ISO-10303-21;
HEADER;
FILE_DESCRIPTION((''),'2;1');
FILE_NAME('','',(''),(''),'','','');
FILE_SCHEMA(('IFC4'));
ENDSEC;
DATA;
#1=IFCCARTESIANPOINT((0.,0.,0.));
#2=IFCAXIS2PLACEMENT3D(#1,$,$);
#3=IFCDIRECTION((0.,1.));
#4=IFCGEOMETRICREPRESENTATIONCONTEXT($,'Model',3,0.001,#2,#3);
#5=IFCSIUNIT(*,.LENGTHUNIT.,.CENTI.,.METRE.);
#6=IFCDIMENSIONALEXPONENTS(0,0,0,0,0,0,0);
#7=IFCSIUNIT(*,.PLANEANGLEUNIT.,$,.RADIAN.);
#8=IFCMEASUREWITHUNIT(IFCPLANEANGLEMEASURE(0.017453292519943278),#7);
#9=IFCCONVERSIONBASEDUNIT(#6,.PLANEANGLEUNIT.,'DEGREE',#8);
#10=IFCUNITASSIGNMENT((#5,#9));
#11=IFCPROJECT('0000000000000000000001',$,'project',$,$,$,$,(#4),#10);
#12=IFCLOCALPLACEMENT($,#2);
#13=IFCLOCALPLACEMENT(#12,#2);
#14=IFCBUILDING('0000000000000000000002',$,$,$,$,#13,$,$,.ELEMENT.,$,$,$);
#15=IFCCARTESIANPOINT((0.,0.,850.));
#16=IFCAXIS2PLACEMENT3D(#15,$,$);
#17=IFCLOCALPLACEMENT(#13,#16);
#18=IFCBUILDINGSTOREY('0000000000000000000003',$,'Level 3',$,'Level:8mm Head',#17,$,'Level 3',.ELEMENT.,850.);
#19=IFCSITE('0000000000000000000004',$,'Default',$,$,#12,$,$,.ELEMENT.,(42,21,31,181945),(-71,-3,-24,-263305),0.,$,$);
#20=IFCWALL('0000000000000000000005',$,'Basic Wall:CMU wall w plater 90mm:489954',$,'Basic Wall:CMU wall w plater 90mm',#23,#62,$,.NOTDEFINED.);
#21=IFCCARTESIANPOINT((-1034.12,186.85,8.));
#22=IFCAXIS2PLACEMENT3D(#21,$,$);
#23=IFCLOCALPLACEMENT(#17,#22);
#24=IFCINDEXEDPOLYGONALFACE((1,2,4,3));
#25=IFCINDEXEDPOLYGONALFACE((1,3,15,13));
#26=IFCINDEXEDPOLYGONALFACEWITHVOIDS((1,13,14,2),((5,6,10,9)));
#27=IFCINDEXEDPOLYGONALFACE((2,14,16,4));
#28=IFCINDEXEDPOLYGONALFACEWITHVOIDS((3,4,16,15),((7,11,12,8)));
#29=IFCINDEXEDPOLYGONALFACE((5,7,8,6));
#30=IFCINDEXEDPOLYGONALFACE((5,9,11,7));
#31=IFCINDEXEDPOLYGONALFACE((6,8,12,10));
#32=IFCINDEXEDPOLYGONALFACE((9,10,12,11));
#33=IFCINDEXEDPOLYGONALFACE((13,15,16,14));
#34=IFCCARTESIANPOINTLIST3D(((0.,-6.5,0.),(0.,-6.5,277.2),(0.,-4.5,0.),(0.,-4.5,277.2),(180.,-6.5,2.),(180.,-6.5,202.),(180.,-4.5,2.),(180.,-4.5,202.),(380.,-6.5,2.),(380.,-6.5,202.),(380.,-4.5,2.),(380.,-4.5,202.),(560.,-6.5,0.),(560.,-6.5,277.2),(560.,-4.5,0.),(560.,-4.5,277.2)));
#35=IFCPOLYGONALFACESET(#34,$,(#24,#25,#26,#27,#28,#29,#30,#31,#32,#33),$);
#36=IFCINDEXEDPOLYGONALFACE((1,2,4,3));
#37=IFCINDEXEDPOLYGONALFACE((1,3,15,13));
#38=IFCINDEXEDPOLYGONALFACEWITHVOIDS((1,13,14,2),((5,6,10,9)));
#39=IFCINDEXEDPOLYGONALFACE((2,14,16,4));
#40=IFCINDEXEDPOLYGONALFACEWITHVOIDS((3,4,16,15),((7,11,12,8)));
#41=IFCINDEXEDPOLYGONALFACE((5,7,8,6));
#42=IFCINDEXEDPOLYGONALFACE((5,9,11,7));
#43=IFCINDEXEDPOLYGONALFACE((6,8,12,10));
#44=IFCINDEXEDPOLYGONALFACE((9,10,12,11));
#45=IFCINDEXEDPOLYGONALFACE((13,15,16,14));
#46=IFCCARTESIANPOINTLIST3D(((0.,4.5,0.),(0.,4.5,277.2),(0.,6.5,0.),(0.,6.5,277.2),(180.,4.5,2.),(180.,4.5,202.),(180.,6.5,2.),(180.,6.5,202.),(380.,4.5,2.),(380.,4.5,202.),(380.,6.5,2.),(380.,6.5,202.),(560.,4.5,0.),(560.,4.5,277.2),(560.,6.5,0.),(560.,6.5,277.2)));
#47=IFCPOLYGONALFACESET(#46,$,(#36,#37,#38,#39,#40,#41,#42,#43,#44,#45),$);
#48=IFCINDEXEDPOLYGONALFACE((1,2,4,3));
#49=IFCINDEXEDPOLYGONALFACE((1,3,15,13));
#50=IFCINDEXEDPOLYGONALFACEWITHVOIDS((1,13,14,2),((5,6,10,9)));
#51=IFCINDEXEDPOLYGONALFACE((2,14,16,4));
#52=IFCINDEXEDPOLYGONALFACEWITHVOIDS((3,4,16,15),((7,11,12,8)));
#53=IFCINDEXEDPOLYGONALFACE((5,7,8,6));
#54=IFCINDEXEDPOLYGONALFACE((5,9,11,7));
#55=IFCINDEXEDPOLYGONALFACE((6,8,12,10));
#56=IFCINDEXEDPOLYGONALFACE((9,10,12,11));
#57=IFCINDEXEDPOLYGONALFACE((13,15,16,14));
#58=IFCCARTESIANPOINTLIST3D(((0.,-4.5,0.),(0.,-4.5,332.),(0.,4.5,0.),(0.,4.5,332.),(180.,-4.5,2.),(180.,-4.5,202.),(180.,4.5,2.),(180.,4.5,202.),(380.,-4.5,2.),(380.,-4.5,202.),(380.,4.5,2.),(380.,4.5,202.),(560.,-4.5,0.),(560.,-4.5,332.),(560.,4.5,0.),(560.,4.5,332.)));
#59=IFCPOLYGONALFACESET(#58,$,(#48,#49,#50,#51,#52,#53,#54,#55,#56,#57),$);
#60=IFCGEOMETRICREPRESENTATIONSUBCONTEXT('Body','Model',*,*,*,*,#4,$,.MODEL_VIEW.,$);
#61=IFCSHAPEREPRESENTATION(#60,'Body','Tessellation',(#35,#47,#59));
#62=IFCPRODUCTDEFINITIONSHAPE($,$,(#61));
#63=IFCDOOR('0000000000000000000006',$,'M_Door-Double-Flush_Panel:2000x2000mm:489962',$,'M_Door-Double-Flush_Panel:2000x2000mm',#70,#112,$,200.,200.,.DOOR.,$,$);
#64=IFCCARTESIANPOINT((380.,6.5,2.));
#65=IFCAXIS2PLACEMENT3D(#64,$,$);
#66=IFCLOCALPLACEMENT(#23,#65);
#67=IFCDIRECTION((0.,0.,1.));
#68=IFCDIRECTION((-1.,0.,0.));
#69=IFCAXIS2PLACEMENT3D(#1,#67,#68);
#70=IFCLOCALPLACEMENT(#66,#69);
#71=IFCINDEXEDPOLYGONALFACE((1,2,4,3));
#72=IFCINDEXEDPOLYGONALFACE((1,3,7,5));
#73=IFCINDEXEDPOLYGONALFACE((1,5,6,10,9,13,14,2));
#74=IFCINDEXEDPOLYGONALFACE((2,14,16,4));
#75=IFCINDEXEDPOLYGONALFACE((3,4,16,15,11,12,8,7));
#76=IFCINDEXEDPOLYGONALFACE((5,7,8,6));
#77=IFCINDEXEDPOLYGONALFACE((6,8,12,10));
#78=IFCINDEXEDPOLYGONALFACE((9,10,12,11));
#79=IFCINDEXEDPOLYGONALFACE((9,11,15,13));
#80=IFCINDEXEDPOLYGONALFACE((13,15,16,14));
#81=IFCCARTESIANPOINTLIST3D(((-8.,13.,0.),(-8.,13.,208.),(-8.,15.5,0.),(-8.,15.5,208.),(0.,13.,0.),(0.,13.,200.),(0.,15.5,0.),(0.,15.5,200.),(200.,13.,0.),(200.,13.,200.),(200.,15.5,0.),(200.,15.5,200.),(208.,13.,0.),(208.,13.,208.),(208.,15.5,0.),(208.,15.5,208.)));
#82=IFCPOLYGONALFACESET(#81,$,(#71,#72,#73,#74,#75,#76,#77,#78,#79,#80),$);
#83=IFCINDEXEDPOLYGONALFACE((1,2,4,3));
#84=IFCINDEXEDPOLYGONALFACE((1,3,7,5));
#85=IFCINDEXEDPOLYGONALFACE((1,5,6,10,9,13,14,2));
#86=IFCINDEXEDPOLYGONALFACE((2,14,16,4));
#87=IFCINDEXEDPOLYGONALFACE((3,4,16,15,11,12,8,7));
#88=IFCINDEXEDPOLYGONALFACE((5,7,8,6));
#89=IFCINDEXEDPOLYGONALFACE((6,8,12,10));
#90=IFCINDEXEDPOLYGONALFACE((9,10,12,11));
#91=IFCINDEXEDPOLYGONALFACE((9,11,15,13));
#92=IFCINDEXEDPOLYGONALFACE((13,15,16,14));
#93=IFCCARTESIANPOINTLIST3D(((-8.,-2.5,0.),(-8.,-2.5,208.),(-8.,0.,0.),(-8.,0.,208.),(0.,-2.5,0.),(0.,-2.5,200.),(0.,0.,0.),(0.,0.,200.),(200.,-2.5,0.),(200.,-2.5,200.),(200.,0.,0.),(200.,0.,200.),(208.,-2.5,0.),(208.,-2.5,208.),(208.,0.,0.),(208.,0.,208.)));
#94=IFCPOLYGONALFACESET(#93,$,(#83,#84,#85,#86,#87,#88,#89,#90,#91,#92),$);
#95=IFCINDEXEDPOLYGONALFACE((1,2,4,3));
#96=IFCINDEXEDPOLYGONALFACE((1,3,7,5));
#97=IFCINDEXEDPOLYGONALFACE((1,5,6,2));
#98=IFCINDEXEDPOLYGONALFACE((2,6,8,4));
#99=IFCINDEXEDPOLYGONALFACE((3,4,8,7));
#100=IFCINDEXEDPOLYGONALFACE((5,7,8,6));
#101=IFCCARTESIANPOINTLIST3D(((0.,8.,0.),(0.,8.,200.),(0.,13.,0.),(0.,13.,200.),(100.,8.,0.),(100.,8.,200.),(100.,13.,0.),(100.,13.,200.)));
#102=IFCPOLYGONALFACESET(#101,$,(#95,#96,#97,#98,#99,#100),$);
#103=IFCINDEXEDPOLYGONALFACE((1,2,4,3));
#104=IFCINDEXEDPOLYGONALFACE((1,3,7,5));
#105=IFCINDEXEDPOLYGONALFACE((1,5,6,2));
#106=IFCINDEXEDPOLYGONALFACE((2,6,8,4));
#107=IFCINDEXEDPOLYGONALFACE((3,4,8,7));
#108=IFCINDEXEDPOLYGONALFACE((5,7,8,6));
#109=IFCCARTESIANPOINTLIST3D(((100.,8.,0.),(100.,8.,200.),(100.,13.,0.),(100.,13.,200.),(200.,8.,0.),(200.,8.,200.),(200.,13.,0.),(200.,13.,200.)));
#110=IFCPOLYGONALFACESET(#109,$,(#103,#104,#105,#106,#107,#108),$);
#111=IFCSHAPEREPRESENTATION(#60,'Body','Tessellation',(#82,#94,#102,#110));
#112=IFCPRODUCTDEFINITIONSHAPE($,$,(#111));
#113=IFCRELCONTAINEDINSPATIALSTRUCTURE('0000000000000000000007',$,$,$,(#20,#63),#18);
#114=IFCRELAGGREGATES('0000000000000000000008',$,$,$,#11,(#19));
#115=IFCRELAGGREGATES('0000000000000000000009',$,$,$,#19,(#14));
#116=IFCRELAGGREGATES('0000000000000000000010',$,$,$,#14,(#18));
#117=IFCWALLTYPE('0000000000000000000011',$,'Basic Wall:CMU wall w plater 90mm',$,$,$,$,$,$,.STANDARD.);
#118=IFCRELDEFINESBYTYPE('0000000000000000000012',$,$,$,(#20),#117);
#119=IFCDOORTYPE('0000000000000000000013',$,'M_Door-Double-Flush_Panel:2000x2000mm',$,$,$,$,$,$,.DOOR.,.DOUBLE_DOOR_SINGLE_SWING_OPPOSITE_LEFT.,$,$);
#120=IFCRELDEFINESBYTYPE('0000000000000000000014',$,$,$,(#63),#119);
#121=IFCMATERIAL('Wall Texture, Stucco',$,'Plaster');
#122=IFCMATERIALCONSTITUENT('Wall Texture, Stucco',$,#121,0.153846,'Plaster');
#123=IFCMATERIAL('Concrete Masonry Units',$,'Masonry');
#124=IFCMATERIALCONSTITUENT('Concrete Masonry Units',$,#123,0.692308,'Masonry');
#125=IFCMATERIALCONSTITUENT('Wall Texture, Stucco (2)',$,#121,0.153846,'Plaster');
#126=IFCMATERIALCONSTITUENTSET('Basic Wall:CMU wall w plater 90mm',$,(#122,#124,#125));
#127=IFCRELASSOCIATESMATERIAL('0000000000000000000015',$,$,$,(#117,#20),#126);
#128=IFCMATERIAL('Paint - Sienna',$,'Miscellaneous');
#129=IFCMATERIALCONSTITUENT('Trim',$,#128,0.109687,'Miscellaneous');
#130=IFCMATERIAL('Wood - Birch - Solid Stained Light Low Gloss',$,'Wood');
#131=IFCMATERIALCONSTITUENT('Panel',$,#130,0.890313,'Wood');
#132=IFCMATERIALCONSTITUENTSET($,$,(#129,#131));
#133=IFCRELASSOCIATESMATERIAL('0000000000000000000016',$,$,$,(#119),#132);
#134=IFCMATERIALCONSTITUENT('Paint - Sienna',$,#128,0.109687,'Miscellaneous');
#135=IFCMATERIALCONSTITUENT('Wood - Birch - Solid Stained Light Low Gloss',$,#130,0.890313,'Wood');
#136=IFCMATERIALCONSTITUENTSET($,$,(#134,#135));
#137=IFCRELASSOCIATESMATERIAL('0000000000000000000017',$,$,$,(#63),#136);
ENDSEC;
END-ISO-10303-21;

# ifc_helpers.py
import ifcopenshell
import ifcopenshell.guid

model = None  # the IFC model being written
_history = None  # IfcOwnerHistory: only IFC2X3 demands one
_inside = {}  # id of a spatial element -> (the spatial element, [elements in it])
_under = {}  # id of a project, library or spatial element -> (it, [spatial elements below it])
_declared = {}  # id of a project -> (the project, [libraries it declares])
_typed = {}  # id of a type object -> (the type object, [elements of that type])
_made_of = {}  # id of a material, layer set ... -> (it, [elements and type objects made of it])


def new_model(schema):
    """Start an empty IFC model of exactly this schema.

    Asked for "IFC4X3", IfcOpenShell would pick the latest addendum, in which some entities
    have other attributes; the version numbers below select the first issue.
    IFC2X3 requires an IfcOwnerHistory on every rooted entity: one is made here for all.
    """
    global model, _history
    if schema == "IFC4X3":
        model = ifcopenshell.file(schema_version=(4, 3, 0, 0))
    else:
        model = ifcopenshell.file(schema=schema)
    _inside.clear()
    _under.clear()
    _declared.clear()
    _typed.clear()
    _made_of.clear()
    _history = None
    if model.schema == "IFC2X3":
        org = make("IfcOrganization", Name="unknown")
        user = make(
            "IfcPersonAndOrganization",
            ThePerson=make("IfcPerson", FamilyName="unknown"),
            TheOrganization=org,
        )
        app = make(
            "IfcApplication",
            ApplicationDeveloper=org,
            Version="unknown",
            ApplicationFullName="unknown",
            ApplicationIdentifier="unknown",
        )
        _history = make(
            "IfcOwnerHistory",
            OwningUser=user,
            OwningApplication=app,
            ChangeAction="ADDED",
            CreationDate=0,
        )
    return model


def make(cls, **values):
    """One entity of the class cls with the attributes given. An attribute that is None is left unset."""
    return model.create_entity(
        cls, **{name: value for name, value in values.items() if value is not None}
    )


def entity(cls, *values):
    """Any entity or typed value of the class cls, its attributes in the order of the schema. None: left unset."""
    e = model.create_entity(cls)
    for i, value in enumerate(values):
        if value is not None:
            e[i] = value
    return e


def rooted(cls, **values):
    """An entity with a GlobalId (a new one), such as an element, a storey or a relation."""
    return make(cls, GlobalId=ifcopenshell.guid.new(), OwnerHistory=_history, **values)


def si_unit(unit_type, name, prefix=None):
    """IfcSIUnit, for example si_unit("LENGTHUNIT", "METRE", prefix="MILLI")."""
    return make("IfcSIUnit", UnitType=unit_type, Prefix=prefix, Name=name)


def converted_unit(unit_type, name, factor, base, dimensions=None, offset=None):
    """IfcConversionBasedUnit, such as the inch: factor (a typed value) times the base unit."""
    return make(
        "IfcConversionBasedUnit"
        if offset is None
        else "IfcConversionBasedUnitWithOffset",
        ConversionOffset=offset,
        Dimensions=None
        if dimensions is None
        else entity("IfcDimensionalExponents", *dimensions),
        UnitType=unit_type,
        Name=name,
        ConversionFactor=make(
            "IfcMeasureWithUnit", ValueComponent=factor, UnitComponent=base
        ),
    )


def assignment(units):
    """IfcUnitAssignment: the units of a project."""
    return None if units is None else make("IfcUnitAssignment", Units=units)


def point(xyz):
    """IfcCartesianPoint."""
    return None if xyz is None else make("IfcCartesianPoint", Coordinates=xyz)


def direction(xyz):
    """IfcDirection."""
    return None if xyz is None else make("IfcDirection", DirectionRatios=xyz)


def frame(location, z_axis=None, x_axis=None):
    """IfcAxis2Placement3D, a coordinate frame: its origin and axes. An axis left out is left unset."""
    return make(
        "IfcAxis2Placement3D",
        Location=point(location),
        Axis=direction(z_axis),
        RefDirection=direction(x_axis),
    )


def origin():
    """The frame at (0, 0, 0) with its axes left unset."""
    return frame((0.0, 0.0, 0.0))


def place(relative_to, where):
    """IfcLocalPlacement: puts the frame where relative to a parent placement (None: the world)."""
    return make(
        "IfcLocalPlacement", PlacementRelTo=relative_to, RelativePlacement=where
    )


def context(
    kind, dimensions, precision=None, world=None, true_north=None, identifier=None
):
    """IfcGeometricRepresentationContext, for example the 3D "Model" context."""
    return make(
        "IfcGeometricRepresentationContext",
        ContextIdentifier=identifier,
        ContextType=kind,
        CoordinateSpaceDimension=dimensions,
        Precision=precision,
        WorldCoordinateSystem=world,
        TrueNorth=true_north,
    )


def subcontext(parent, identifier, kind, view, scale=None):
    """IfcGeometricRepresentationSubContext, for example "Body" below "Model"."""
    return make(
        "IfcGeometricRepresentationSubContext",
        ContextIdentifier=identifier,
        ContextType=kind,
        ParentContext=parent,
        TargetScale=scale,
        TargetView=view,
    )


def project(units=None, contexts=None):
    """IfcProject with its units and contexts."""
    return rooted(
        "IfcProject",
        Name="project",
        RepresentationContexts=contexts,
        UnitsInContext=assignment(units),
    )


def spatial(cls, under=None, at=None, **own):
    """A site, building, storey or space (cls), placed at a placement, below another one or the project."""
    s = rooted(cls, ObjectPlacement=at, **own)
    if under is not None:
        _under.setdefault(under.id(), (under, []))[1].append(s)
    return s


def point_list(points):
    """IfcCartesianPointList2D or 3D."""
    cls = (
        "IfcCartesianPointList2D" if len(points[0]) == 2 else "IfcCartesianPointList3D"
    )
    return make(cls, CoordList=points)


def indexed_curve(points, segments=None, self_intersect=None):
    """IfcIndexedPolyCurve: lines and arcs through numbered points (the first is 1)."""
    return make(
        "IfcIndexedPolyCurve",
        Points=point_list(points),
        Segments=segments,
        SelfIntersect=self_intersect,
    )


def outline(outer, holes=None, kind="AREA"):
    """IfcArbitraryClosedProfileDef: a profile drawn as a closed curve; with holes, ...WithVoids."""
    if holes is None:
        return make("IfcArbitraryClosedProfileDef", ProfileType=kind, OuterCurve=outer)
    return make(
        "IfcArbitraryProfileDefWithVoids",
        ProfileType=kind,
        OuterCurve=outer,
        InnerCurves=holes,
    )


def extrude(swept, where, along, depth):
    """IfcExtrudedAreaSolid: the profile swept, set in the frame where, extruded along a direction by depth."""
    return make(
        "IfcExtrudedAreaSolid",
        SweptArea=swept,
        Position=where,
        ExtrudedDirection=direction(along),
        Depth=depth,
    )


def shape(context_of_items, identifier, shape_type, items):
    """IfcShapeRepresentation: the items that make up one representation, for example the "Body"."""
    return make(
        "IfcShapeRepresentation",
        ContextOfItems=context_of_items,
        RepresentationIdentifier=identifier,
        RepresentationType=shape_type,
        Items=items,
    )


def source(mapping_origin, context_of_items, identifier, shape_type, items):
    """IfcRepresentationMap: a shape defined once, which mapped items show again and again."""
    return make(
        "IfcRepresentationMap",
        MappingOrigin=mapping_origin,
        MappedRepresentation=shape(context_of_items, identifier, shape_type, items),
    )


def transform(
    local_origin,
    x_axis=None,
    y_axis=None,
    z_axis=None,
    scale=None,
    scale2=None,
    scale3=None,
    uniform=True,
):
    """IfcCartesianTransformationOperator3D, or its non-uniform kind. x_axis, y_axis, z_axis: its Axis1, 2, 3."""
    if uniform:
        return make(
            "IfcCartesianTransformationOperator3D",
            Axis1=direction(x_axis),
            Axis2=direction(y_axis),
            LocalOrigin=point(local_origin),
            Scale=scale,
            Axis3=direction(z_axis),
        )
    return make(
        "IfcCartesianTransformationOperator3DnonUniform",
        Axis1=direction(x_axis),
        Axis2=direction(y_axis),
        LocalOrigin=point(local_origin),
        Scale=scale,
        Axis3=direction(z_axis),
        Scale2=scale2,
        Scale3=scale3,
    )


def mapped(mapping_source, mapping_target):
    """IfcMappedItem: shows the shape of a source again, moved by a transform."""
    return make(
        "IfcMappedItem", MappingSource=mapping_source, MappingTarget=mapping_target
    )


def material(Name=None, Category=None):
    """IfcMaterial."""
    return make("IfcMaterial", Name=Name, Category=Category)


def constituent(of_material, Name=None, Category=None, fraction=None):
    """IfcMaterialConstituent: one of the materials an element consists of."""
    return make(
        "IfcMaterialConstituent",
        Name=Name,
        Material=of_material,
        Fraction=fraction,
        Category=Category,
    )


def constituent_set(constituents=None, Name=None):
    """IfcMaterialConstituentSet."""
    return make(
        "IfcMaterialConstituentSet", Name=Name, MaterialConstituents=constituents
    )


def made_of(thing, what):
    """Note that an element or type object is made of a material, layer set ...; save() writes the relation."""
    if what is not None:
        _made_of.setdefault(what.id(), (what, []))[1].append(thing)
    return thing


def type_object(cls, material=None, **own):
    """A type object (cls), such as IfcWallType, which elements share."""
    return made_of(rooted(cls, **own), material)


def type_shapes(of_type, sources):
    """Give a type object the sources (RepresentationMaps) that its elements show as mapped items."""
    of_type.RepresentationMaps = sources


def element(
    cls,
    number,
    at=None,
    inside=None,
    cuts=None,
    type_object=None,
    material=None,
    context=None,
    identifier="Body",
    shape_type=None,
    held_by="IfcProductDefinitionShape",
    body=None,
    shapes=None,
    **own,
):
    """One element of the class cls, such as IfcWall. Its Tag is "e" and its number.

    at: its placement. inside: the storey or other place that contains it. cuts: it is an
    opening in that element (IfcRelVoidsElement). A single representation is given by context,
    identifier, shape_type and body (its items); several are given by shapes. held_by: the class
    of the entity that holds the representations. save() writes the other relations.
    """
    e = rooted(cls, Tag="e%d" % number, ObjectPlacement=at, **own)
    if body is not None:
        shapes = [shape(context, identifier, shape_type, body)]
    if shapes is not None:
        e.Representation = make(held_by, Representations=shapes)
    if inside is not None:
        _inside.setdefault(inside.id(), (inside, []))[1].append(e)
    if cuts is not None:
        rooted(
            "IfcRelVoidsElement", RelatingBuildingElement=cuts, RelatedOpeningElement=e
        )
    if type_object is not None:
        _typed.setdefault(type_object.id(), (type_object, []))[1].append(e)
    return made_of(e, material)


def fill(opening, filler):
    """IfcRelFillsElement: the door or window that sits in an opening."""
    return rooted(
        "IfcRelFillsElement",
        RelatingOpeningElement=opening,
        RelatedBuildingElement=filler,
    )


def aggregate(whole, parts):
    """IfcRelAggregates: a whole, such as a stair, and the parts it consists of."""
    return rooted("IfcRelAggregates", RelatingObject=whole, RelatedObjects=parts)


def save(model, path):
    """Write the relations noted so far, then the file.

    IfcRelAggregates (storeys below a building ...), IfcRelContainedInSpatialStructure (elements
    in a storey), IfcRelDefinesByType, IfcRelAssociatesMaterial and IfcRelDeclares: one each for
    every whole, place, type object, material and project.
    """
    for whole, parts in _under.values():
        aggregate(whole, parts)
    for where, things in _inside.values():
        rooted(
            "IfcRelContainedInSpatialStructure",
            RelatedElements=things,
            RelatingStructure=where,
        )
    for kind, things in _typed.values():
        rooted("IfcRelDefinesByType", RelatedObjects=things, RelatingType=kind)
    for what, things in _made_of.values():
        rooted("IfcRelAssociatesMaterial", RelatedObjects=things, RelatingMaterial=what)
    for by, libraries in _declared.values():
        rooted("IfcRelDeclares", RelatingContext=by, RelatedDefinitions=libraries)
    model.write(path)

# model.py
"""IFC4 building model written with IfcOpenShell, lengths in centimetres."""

from ifc_helpers import new_model, entity, si_unit, converted_unit, direction, frame, origin, place, context, subcontext, project, spatial, indexed_curve, outline, extrude, source, transform, mapped, material, constituent, constituent_set, type_object, type_shapes, element, fill, save


model = new_model("IFC4")

# Units and contexts
model_context = context("Model", 3, precision=0.001, world=origin(), true_north=direction((0.0, 1.0)))
body_context = subcontext(model_context, "Body", "Model", "MODEL_VIEW")
ifc_project = project(units=[si_unit("LENGTHUNIT", "METRE", prefix="CENTI"), converted_unit("PLANEANGLEUNIT", "DEGREE", entity("IfcPlaneAngleMeasure", 0.017453292519943278), si_unit("PLANEANGLEUNIT", "RADIAN"), dimensions=[0, 0, 0, 0, 0, 0, 0])], contexts=[model_context])

# Site, building, storey
site_placement = place(None, origin())
site = spatial("IfcSite", under=ifc_project, at=site_placement, Name="Default", CompositionType="ELEMENT", RefLatitude=(42, 21, 31, 181945), RefLongitude=(-71, -3, -24, -263305), RefElevation=0.0)
building_placement = place(site_placement, origin())
building = spatial("IfcBuilding", under=site, at=building_placement, CompositionType="ELEMENT")
storey_placement = place(building_placement, frame((0.0, 0.0, 850.0)))
storey = spatial("IfcBuildingStorey", under=building, at=storey_placement, Name="Level 3", ObjectType="Level:8mm Head", LongName="Level 3", CompositionType="ELEMENT", Elevation=850.0)

# Shared definitions
ifc_material_1 = material(Name="Concrete Masonry Units", Category="Masonry")

# Shared definitions
ifc_material_2 = material(Name="Wall Texture, Stucco", Category="Plaster")
ifc_constituent_1 = constituent(ifc_material_2, Name="Wall Texture, Stucco", Category="Plaster", fraction=0.153846)
ifc_constituent_2 = constituent(ifc_material_1, Name="Concrete Masonry Units", Category="Masonry", fraction=0.692308)
ifc_constituent_3 = constituent(ifc_material_2, Name="Wall Texture, Stucco (2)", Category="Plaster", fraction=0.153846)
ifc_constituent_set_1 = constituent_set(constituents=[ifc_constituent_1, ifc_constituent_2, ifc_constituent_3], Name="Basic Wall:CMU wall w plater 90mm")
wall_type_1 = type_object("IfcWallType", Name="Basic Wall:CMU wall w plater 90mm", PredefinedType="STANDARD", material=ifc_constituent_set_1)

# Wall, opening, door
wall_1_placement = place(storey_placement, frame((-1034.12, 186.85, 8.0)))
wall_1 = element("IfcWall", 1, at=wall_1_placement, inside=storey, type_object=wall_type_1, material=ifc_constituent_set_1, Name="Basic Wall:CMU wall w plater 90mm:489954", ObjectType="Basic Wall:CMU wall w plater 90mm", PredefinedType="NOTDEFINED", context=body_context, shape_type="SweptSolid", body=[
    extrude(outline(indexed_curve([(-138.6, -280.0), (138.6, -280.0), (138.6, -278.0), (138.6, 278.0), (138.6, 280.0), (-138.6, 280.0), (-138.6, 278.0), (-138.6, -278.0), (-138.6, -280.0)], self_intersect=False), holes=[indexed_curve([(-136.6, -100.0), (-136.6, 100.0), (63.4, 100.0), (63.4, -100.0), (-136.6, -100.0)], self_intersect=False)]), frame((280.0, -6.5, 138.6), z_axis=(0.0, 1.0, 0.0), x_axis=(0.0, 0.0, 1.0)), (0.0, 0.0, 1.0), 2.0),
    extrude(outline(indexed_curve([(-138.6, -280.0), (138.6, -280.0), (138.6, 280.0), (-138.6, 280.0), (-138.6, -280.0)], self_intersect=False), holes=[indexed_curve([(-136.6, -100.0), (-136.6, 100.0), (63.4, 100.0), (63.4, -100.0), (-136.6, -100.0)], self_intersect=False)]), frame((280.0, 4.5, 138.6), z_axis=(0.0, 1.0, 0.0), x_axis=(0.0, 0.0, 1.0)), (0.0, 0.0, 1.0), 2.0),
    extrude(outline(indexed_curve([(-203.07, -280.0), (74.13, -280.0), (128.93, -280.0), (128.93, 280.0), (74.13, 280.0), (-203.07, 280.0), (-203.07, -280.0)], self_intersect=False), holes=[indexed_curve([(-201.07, -100.0), (-201.07, 100.0), (-1.07, 100.0), (-1.07, -100.0), (-201.07, -100.0)], self_intersect=False)]), frame((280.0, -4.5, 203.07), z_axis=(0.0, 1.0, 0.0), x_axis=(0.0, 0.0, 1.0)), (0.0, 0.0, 1.0), 9.0),
])
opening_1_placement = place(wall_1_placement, frame((380.0, 6.5, 2.0)))
opening_1 = element("IfcOpeningElement", 2, at=opening_1_placement, cuts=wall_1, PredefinedType="OPENING", context=body_context, shape_type="SweptSolid", body=[
    extrude(outline(indexed_curve([(0.0, 200.0), (0.0, 0.0), (200.0, 0.0), (200.0, 200.0), (0.0, 200.0)], self_intersect=False)), frame((0.0, 0.0, 0.0), z_axis=(0.0, -1.0, 0.0), x_axis=(0.0, 0.0, 1.0)), (0.0, 0.0, 1.0), 13.0),
])
ifc_material_3 = material(Name="Paint - Sienna", Category="Miscellaneous")
ifc_constituent_4 = constituent(ifc_material_3, Name="Paint - Sienna", Category="Miscellaneous", fraction=0.109687)
ifc_material_4 = material(Name="Wood - Birch - Solid Stained Light Low Gloss", Category="Wood")
ifc_constituent_5 = constituent(ifc_material_4, Name="Wood - Birch - Solid Stained Light Low Gloss", Category="Wood", fraction=0.890313)
ifc_constituent_set_2 = constituent_set(constituents=[ifc_constituent_4, ifc_constituent_5])
ifc_constituent_6 = constituent(ifc_material_3, Name="Trim", Category="Miscellaneous", fraction=0.109687)
ifc_constituent_7 = constituent(ifc_material_4, Name="Panel", Category="Wood", fraction=0.890313)
ifc_constituent_set_3 = constituent_set(constituents=[ifc_constituent_6, ifc_constituent_7])
door_type = type_object("IfcDoorType", Name="M_Door-Double-Flush_Panel:2000x2000mm", OperationType="DOUBLE_DOOR_SINGLE_SWING_OPPOSITE_LEFT", PredefinedType="DOOR", material=ifc_constituent_set_3)
shared_shape_1 = source(origin(), body_context, "Body", "SweptSolid", [
    extrude(outline(indexed_curve([(-98.0, 100.0), (102.0, 100.0), (102.0, 108.0), (-106.0, 108.0), (-106.0, -108.0), (102.0, -108.0), (102.0, -100.0), (-98.0, -100.0), (-98.0, 100.0)], self_intersect=False)), frame((100.0, 13.0, 102.0), z_axis=(0.0, 1.0, 0.0), x_axis=(0.0, 0.0, -1.0)), (0.0, 0.0, 1.0), 2.5),
    extrude(outline(indexed_curve([(-98.0, 100.0), (102.0, 100.0), (102.0, 108.0), (-106.0, 108.0), (-106.0, -108.0), (102.0, -108.0), (102.0, -100.0), (-98.0, -100.0), (-98.0, 100.0)], self_intersect=False)), frame((100.0, -2.5, 102.0), z_axis=(0.0, 1.0, 0.0), x_axis=(0.0, 0.0, -1.0)), (0.0, 0.0, 1.0), 2.5),
    extrude(outline(indexed_curve([(-2.5, -50.0), (2.5, -50.0), (2.5, 50.0), (-2.5, 50.0), (-2.5, -50.0)], self_intersect=False)), frame((50.0, 10.5, 0.0), z_axis=(0.0, 0.0, 1.0), x_axis=(0.0, -1.0, 0.0)), (0.0, 0.0, 1.0), 200.0),
    extrude(outline(indexed_curve([(-2.5, -50.0), (2.5, -50.0), (2.5, 50.0), (-2.5, 50.0), (-2.5, -50.0)], self_intersect=False)), frame((150.0, 10.5, 0.0), z_axis=(0.0, 0.0, 1.0), x_axis=(0.0, -1.0, 0.0)), (0.0, 0.0, 1.0), 200.0),
])
type_shapes(door_type, [shared_shape_1])
door_placement = place(opening_1_placement, frame((0.0, 0.0, 0.0), z_axis=(0.0, 0.0, 1.0), x_axis=(-1.0, 0.0, 0.0)))
door = element("IfcDoor", 3, at=door_placement, inside=storey, type_object=door_type, material=ifc_constituent_set_2, Name="M_Door-Double-Flush_Panel:2000x2000mm:489962", ObjectType="M_Door-Double-Flush_Panel:2000x2000mm", OverallHeight=200.0, OverallWidth=200.0, PredefinedType="DOOR", context=body_context, shape_type="MappedRepresentation", body=[
    mapped(shared_shape_1, transform((0.0, 0.0, 0.0), scale=1.0)),
])
fill(opening_1, door)

save(model, "model.ifc")
